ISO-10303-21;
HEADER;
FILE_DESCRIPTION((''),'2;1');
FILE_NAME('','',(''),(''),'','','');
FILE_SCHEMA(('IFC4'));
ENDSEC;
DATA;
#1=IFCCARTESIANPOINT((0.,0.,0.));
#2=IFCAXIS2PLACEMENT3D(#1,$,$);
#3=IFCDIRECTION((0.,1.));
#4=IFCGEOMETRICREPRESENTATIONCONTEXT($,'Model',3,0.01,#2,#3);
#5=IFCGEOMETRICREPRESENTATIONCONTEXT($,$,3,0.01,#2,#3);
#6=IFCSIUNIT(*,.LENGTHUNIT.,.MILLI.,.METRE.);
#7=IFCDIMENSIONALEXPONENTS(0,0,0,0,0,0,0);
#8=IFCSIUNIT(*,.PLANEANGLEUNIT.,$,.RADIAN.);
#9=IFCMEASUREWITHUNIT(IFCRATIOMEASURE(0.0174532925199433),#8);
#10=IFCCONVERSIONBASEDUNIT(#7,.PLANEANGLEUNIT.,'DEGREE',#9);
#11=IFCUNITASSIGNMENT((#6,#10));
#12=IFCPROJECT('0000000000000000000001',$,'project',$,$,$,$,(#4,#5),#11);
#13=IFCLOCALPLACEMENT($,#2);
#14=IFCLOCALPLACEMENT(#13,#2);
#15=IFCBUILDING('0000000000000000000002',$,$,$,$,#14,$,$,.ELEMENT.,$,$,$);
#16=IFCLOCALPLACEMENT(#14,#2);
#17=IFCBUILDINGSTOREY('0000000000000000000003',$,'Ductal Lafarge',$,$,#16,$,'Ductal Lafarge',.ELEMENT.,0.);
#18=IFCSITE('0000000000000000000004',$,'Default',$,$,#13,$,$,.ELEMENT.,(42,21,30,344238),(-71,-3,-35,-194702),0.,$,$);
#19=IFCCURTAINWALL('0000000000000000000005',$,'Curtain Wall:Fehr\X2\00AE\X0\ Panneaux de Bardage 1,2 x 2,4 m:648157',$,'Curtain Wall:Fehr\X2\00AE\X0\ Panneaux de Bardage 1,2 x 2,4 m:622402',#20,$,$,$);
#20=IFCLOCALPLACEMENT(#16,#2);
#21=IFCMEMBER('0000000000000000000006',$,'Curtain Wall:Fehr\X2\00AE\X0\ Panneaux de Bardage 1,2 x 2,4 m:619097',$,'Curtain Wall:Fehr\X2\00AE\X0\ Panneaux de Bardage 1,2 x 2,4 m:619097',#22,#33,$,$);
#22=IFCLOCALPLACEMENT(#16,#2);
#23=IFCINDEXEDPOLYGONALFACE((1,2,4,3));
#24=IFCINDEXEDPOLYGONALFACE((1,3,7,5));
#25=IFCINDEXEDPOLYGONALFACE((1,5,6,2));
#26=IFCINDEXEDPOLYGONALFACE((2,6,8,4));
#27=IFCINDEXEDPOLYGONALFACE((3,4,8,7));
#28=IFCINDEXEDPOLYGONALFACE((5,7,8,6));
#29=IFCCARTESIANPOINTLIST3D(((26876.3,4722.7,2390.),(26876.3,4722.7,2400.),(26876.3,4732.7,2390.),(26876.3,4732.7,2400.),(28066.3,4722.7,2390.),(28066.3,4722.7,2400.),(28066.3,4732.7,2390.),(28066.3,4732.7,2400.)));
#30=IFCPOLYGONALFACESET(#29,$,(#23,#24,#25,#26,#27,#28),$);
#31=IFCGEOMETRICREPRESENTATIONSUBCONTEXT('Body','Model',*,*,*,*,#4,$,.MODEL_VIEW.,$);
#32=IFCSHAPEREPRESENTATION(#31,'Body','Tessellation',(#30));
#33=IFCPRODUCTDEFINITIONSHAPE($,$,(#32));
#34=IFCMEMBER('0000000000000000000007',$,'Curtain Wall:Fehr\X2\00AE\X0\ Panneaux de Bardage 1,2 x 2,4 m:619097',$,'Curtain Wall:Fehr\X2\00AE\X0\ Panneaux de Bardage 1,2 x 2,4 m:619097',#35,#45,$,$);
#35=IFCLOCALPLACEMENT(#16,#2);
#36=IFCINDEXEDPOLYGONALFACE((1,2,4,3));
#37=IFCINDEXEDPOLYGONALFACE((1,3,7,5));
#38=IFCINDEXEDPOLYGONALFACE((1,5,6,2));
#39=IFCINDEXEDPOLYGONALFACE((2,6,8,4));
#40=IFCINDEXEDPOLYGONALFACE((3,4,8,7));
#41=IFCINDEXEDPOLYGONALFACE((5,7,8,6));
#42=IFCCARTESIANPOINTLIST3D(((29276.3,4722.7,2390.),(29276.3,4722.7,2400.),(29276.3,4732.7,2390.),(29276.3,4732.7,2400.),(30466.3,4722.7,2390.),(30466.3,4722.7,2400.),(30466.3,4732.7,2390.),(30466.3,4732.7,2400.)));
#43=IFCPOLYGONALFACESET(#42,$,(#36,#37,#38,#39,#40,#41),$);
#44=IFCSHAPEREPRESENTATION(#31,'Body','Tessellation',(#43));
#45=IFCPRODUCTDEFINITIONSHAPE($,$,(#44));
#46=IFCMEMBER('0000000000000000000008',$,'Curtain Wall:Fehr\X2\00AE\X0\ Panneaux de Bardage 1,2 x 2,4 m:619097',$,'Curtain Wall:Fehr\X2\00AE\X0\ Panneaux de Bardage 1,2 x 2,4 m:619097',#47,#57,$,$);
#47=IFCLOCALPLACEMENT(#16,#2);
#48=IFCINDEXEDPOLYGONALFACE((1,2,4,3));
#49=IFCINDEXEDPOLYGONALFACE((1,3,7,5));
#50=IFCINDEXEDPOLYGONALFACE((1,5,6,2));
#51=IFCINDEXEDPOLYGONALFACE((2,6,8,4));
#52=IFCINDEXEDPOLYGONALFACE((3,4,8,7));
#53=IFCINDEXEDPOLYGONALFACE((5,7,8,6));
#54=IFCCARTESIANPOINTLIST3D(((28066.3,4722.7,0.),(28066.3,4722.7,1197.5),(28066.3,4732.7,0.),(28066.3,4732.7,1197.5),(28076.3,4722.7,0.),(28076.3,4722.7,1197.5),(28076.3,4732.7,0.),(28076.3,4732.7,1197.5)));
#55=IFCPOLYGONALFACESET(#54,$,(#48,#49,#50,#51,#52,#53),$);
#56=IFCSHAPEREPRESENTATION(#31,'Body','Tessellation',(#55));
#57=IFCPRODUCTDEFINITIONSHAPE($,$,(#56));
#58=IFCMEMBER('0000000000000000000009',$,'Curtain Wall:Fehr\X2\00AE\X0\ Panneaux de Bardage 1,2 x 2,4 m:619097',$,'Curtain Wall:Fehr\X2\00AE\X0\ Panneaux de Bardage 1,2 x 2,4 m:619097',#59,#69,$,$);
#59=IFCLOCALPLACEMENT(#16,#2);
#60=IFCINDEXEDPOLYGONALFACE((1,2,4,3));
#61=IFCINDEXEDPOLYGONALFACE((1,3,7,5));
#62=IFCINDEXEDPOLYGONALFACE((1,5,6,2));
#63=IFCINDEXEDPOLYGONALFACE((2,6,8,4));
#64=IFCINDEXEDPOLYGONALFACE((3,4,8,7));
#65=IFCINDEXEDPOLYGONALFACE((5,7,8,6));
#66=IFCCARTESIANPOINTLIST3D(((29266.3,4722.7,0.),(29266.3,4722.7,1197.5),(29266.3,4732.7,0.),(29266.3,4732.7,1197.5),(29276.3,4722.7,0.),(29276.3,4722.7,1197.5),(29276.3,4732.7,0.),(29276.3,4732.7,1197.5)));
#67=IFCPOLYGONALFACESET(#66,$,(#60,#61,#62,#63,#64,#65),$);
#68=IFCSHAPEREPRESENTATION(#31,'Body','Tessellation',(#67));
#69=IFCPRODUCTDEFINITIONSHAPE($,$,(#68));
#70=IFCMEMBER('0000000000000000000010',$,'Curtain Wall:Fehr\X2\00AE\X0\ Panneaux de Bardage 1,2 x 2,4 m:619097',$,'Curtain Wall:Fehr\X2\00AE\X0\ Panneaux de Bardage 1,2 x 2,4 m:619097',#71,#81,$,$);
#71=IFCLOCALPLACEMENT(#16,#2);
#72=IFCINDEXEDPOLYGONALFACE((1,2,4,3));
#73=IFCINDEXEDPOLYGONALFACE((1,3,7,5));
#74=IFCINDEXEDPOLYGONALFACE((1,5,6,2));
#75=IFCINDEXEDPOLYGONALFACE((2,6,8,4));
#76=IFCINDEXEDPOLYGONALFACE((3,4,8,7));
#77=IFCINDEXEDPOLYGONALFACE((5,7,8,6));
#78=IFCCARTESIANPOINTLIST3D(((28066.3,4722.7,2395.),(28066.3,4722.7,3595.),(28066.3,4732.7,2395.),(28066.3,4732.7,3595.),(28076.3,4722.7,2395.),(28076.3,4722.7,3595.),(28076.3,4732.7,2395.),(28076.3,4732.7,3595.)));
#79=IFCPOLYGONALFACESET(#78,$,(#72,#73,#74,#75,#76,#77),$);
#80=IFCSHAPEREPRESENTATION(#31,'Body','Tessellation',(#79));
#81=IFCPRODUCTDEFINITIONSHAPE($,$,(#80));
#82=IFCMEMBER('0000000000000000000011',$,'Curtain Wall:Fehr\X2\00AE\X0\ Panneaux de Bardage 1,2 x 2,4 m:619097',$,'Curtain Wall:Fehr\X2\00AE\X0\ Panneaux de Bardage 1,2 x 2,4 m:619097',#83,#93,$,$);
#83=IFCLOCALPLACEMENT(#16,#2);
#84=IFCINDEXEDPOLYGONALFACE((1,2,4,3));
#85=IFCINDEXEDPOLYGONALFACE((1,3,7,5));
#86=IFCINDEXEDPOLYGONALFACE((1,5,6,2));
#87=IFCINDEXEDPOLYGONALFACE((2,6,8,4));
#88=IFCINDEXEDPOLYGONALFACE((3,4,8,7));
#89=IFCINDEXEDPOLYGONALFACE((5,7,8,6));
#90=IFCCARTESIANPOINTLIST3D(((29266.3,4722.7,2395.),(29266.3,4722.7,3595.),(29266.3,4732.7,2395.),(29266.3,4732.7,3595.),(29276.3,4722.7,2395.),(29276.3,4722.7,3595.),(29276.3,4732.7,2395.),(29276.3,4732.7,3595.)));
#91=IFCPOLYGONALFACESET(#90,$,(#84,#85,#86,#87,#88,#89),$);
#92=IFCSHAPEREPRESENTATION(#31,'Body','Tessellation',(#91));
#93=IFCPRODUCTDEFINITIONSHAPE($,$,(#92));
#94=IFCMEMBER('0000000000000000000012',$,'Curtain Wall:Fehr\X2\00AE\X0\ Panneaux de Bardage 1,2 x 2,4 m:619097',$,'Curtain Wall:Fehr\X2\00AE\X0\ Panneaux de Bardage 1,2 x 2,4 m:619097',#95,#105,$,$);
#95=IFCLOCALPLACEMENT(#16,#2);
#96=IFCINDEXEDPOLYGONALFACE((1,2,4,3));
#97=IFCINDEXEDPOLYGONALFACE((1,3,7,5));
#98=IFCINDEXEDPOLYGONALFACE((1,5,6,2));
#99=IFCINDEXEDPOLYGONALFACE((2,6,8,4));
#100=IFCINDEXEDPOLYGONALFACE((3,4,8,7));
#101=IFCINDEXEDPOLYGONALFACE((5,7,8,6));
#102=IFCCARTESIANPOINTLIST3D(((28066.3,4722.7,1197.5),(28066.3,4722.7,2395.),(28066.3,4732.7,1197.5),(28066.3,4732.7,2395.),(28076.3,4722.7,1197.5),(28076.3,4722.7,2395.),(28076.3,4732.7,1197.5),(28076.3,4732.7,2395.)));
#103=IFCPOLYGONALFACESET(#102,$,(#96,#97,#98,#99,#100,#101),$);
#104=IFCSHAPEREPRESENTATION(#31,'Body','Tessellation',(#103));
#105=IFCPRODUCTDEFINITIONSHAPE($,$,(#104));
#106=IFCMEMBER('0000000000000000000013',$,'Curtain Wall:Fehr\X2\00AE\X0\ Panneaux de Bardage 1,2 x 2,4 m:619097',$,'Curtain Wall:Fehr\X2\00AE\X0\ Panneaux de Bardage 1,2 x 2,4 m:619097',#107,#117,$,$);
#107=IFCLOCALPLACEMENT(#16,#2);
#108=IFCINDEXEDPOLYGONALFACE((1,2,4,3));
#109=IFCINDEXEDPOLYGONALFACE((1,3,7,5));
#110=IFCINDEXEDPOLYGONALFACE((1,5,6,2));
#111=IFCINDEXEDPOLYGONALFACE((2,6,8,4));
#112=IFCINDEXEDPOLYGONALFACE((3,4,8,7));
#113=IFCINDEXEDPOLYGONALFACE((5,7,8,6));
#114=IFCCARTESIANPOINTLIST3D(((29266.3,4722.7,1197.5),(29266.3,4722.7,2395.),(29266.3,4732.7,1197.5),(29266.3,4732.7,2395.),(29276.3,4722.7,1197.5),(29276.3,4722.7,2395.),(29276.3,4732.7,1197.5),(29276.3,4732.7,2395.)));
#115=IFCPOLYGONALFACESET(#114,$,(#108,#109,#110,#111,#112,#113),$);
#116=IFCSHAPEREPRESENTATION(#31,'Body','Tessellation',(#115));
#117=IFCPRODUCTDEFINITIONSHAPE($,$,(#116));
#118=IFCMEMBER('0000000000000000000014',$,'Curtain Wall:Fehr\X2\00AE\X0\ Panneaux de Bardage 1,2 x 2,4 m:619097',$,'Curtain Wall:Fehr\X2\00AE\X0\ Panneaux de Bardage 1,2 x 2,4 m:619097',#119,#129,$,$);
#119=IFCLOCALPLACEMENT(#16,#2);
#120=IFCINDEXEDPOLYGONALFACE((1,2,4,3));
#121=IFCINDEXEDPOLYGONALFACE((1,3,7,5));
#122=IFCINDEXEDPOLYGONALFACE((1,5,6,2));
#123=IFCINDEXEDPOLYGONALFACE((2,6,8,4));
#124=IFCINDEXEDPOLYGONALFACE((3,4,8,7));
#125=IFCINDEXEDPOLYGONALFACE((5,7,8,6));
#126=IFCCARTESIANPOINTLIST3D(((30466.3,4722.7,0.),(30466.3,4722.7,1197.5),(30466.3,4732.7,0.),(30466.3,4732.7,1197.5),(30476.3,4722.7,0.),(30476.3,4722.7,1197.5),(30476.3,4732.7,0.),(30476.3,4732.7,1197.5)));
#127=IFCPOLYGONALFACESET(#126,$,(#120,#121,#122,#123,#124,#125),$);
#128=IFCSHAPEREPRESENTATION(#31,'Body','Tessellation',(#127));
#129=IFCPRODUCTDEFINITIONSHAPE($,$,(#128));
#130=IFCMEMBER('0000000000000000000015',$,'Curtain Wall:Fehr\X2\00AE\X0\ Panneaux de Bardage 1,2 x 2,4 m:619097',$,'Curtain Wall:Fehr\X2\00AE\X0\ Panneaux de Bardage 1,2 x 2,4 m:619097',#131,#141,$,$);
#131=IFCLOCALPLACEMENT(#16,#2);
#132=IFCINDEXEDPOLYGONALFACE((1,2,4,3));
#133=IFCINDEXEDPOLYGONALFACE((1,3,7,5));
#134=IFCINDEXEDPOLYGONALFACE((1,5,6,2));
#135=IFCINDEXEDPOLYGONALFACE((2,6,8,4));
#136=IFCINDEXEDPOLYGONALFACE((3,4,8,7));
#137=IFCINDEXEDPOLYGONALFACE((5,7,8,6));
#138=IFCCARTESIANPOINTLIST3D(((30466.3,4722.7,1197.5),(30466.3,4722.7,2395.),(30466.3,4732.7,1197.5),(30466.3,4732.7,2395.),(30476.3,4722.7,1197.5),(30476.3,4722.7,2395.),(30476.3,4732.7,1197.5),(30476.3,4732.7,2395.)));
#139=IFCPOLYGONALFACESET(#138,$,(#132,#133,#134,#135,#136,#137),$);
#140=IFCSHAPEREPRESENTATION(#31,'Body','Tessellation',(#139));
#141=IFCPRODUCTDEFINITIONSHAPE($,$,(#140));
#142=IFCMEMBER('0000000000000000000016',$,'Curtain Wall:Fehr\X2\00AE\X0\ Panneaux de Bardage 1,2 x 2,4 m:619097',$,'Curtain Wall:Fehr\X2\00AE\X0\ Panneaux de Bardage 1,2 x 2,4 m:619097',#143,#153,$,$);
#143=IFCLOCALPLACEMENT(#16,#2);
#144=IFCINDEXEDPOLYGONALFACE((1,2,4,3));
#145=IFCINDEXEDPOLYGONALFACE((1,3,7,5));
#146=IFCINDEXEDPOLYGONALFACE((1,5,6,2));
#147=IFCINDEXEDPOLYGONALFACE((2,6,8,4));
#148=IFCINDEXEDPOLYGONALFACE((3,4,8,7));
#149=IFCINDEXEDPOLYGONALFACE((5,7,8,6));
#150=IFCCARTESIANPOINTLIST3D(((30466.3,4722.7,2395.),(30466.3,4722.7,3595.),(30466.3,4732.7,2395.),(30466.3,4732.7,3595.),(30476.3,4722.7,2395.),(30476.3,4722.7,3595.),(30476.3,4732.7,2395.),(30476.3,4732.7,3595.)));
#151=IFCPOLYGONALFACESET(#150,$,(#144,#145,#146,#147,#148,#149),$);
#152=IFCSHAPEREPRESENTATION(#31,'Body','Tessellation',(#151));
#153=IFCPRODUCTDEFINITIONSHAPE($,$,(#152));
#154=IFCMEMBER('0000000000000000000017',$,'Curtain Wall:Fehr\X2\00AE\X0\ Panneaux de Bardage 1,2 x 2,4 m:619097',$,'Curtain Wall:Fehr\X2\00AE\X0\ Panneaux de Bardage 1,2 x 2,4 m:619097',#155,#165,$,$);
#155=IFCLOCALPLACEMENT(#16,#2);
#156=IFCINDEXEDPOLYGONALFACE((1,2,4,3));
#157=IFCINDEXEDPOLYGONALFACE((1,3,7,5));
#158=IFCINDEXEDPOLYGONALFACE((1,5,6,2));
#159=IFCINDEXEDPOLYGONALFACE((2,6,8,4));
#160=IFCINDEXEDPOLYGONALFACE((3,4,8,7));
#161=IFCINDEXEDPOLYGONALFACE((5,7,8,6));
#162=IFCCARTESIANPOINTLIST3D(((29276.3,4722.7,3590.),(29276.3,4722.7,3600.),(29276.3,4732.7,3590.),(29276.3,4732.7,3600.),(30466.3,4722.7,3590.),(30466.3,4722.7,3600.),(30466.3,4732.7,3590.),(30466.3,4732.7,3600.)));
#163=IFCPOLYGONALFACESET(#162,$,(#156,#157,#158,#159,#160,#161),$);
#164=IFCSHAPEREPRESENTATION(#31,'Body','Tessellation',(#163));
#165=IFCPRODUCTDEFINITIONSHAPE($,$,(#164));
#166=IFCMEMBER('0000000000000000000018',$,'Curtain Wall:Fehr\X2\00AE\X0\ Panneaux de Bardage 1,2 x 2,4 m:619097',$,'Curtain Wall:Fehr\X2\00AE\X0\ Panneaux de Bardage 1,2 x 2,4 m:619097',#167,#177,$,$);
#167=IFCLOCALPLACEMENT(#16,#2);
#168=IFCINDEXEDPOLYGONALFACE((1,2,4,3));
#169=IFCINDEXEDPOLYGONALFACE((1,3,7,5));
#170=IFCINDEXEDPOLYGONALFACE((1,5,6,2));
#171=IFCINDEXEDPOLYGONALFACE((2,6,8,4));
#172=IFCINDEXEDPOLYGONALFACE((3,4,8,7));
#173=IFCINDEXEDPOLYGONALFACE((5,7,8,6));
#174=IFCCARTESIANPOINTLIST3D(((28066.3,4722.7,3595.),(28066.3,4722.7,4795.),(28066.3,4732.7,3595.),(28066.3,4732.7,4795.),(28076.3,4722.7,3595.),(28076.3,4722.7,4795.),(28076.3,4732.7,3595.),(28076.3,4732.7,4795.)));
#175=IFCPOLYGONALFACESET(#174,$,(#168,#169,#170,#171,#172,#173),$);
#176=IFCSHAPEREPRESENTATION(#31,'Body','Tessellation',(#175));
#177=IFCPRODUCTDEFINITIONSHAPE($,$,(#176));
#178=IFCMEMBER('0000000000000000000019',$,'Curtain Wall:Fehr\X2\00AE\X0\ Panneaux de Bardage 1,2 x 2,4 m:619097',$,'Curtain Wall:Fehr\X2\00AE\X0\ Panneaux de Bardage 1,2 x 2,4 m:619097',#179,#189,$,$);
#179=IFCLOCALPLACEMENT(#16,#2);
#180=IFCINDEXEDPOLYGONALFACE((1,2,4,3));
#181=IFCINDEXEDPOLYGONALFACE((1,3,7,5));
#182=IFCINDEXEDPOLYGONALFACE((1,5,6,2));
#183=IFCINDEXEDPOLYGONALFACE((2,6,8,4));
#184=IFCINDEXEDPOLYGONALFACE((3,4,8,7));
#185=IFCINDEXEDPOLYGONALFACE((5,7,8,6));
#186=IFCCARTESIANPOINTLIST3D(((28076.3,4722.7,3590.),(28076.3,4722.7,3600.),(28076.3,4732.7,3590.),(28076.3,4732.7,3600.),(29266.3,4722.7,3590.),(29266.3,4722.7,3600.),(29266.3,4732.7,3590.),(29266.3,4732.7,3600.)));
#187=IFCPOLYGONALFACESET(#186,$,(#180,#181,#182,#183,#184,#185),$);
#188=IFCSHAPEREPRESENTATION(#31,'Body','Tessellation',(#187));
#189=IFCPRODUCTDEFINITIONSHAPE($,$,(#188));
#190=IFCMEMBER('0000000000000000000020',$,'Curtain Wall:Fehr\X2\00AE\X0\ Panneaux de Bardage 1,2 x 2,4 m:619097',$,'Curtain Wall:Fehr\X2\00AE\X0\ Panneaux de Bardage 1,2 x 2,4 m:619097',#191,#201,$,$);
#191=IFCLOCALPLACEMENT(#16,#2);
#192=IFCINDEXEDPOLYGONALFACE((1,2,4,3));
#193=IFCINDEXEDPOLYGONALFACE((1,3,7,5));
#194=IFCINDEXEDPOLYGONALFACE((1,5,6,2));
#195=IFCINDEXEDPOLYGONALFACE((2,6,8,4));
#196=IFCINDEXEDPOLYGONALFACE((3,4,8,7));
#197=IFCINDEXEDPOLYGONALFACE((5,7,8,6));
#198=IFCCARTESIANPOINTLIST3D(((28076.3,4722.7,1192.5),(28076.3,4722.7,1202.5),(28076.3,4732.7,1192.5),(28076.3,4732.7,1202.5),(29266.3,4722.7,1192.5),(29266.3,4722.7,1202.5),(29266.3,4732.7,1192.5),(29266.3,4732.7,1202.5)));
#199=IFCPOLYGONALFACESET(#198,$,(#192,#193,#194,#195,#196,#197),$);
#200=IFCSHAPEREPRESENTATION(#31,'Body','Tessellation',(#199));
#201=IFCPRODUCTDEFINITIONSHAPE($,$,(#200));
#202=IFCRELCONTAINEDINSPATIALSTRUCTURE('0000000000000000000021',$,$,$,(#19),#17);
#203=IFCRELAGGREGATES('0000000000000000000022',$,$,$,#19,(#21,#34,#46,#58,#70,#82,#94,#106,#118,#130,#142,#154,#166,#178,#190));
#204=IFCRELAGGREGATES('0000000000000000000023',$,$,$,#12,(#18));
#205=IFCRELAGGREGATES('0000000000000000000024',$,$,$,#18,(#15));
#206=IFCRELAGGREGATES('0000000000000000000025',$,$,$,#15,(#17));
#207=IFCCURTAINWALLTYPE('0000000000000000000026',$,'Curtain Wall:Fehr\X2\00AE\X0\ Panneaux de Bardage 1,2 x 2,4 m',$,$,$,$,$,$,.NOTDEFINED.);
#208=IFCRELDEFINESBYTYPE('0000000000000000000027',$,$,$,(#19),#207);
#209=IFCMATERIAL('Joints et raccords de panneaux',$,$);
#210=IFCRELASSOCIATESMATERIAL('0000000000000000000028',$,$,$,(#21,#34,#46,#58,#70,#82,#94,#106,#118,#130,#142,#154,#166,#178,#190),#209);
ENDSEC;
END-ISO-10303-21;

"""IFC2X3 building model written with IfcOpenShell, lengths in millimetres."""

from ifc_helpers import new_model, entity, si_unit, converted_unit, direction, frame, frame_2d, origin, place, context, subcontext, project, spatial, rectangle, extrude, material, type_object, element, aggregate, save


model = new_model("IFC2X3")

# Units and contexts
model_context = context("Model", 3, precision=0.01, world=origin(), true_north=direction((0.0, 1.0)))
context_of_model = context(None, 3, precision=0.01, world=origin(), true_north=direction((0.0, 1.0)))
body_context = subcontext(model_context, "Body", "Model", "MODEL_VIEW")
ifc_project = project(units=[si_unit("LENGTHUNIT", "METRE", prefix="MILLI"), converted_unit("PLANEANGLEUNIT", "DEGREE", entity("IfcRatioMeasure", 0.0174532925199433), si_unit("PLANEANGLEUNIT", "RADIAN"), dimensions=[0, 0, 0, 0, 0, 0, 0])], contexts=[model_context, context_of_model])

# Site, building, storey
site_placement = place(None, origin())
site = spatial("IfcSite", under=ifc_project, at=site_placement, Name="Default", CompositionType="ELEMENT", RefLatitude=(42, 21, 30, 344238), RefLongitude=(-71, -3, -35, -194702), RefElevation=0.0)
building_placement = place(site_placement, origin())
building = spatial("IfcBuilding", under=site, at=building_placement, CompositionType="ELEMENT")
storey_placement = place(building_placement, origin())
storey = spatial("IfcBuildingStorey", under=building, at=storey_placement, Name="Ductal Lafarge", LongName="Ductal Lafarge", CompositionType="ELEMENT", Elevation=0.0)

# Curtain wall, members
curtain_wall_type_1 = type_object("IfcCurtainWallType", Name="Curtain Wall:Fehr® Panneaux de Bardage 1,2 x 2,4 m", PredefinedType="NOTDEFINED")
curtain_wall_1_placement = place(storey_placement, origin())
curtain_wall_1 = element("IfcCurtainWall", 1, at=curtain_wall_1_placement, inside=storey, type_object=curtain_wall_type_1, Name="Curtain Wall:Fehr® Panneaux de Bardage 1,2 x 2,4 m:648157", ObjectType="Curtain Wall:Fehr® Panneaux de Bardage 1,2 x 2,4 m:622402")
ifc_material_1 = material(Name="Joints et raccords de panneaux")
member_1_placement = place(curtain_wall_1_placement, frame((26876.3, 4722.7, 2390.0)))
member_1 = element("IfcMember", 2, at=member_1_placement, material=ifc_material_1, Name="Curtain Wall:Fehr® Panneaux de Bardage 1,2 x 2,4 m:619097", ObjectType="Curtain Wall:Fehr® Panneaux de Bardage 1,2 x 2,4 m:619097", context=body_context, shape_type="SweptSolid", body=[
    extrude(rectangle(XDim=1190.0, YDim=10.0, at=frame_2d((0.0, 0.0), x_axis=(1.0, 0.0))), frame((595.0, 5.0, 0.0), z_axis=(0.0, 0.0, 1.0), x_axis=(-1.0, 0.0, 0.0)), (0.0, 0.0, 1.0), 10.0),
])
member_2_placement = place(curtain_wall_1_placement, frame((29276.3, 4722.7, 2390.0)))
member_2 = element("IfcMember", 3, at=member_2_placement, material=ifc_material_1, Name="Curtain Wall:Fehr® Panneaux de Bardage 1,2 x 2,4 m:619097", ObjectType="Curtain Wall:Fehr® Panneaux de Bardage 1,2 x 2,4 m:619097", context=body_context, shape_type="SweptSolid", body=[
    extrude(rectangle(XDim=1190.0, YDim=10.0, at=frame_2d((0.0, 0.0), x_axis=(1.0, 0.0))), frame((595.0, 5.0, 0.0), z_axis=(0.0, 0.0, 1.0), x_axis=(-1.0, 0.0, 0.0)), (0.0, 0.0, 1.0), 10.0),
])
member_3_placement = place(curtain_wall_1_placement, frame((28066.3, 4722.7, 0.0)))
member_3 = element("IfcMember", 4, at=member_3_placement, material=ifc_material_1, Name="Curtain Wall:Fehr® Panneaux de Bardage 1,2 x 2,4 m:619097", ObjectType="Curtain Wall:Fehr® Panneaux de Bardage 1,2 x 2,4 m:619097", context=body_context, shape_type="SweptSolid", body=[
    extrude(rectangle(XDim=10.0, YDim=10.0, at=frame_2d((0.0, 0.0), x_axis=(1.0, 0.0))), frame((5.0, 5.0, 0.0), z_axis=(0.0, 0.0, 1.0), x_axis=(0.0, 1.0, 0.0)), (0.0, 0.0, 1.0), 1197.5),
])
member_4_placement = place(curtain_wall_1_placement, frame((29266.3, 4722.7, 0.0)))
member_4 = element("IfcMember", 5, at=member_4_placement, material=ifc_material_1, Name="Curtain Wall:Fehr® Panneaux de Bardage 1,2 x 2,4 m:619097", ObjectType="Curtain Wall:Fehr® Panneaux de Bardage 1,2 x 2,4 m:619097", context=body_context, shape_type="SweptSolid", body=[
    extrude(rectangle(XDim=10.0, YDim=10.0, at=frame_2d((0.0, 0.0), x_axis=(1.0, 0.0))), frame((5.0, 5.0, 0.0), z_axis=(0.0, 0.0, 1.0), x_axis=(0.0, 1.0, 0.0)), (0.0, 0.0, 1.0), 1197.5),
])
member_5_placement = place(curtain_wall_1_placement, frame((28066.3, 4722.7, 2395.0)))
member_5 = element("IfcMember", 6, at=member_5_placement, material=ifc_material_1, Name="Curtain Wall:Fehr® Panneaux de Bardage 1,2 x 2,4 m:619097", ObjectType="Curtain Wall:Fehr® Panneaux de Bardage 1,2 x 2,4 m:619097", context=body_context, shape_type="SweptSolid", body=[
    extrude(rectangle(XDim=10.0, YDim=10.0, at=frame_2d((0.0, 0.0), x_axis=(1.0, 0.0))), frame((5.0, 5.0, 0.0), z_axis=(0.0, 0.0, 1.0), x_axis=(0.0, 1.0, 0.0)), (0.0, 0.0, 1.0), 1200.0),
])
member_6_placement = place(curtain_wall_1_placement, frame((29266.3, 4722.7, 2395.0)))
member_6 = element("IfcMember", 7, at=member_6_placement, material=ifc_material_1, Name="Curtain Wall:Fehr® Panneaux de Bardage 1,2 x 2,4 m:619097", ObjectType="Curtain Wall:Fehr® Panneaux de Bardage 1,2 x 2,4 m:619097", context=body_context, shape_type="SweptSolid", body=[
    extrude(rectangle(XDim=10.0, YDim=10.0, at=frame_2d((0.0, 0.0), x_axis=(1.0, 0.0))), frame((5.0, 5.0, 0.0), z_axis=(0.0, 0.0, 1.0), x_axis=(0.0, 1.0, 0.0)), (0.0, 0.0, 1.0), 1200.0),
])
member_7_placement = place(curtain_wall_1_placement, frame((28066.3, 4722.7, 1197.5)))
member_7 = element("IfcMember", 8, at=member_7_placement, material=ifc_material_1, Name="Curtain Wall:Fehr® Panneaux de Bardage 1,2 x 2,4 m:619097", ObjectType="Curtain Wall:Fehr® Panneaux de Bardage 1,2 x 2,4 m:619097", context=body_context, shape_type="SweptSolid", body=[
    extrude(rectangle(XDim=10.0, YDim=10.0, at=frame_2d((0.0, 0.0), x_axis=(1.0, 0.0))), frame((5.0, 5.0, 0.0), z_axis=(0.0, 0.0, 1.0), x_axis=(0.0, 1.0, 0.0)), (0.0, 0.0, 1.0), 1197.5),
])
member_8_placement = place(curtain_wall_1_placement, frame((29266.3, 4722.7, 1197.5)))
member_8 = element("IfcMember", 9, at=member_8_placement, material=ifc_material_1, Name="Curtain Wall:Fehr® Panneaux de Bardage 1,2 x 2,4 m:619097", ObjectType="Curtain Wall:Fehr® Panneaux de Bardage 1,2 x 2,4 m:619097", context=body_context, shape_type="SweptSolid", body=[
    extrude(rectangle(XDim=10.0, YDim=10.0, at=frame_2d((0.0, 0.0), x_axis=(1.0, 0.0))), frame((5.0, 5.0, 0.0), z_axis=(0.0, 0.0, 1.0), x_axis=(0.0, 1.0, 0.0)), (0.0, 0.0, 1.0), 1197.5),
])
member_9_placement = place(curtain_wall_1_placement, frame((30466.3, 4722.7, 0.0)))
member_9 = element("IfcMember", 10, at=member_9_placement, material=ifc_material_1, Name="Curtain Wall:Fehr® Panneaux de Bardage 1,2 x 2,4 m:619097", ObjectType="Curtain Wall:Fehr® Panneaux de Bardage 1,2 x 2,4 m:619097", context=body_context, shape_type="SweptSolid", body=[
    extrude(rectangle(XDim=10.0, YDim=10.0, at=frame_2d((0.0, 0.0), x_axis=(1.0, 0.0))), frame((5.0, 5.0, 0.0), z_axis=(0.0, 0.0, 1.0), x_axis=(0.0, 1.0, 0.0)), (0.0, 0.0, 1.0), 1197.5),
])
member_10_placement = place(curtain_wall_1_placement, frame((30466.3, 4722.7, 1197.5)))
member_10 = element("IfcMember", 11, at=member_10_placement, material=ifc_material_1, Name="Curtain Wall:Fehr® Panneaux de Bardage 1,2 x 2,4 m:619097", ObjectType="Curtain Wall:Fehr® Panneaux de Bardage 1,2 x 2,4 m:619097", context=body_context, shape_type="SweptSolid", body=[
    extrude(rectangle(XDim=10.0, YDim=10.0, at=frame_2d((0.0, 0.0), x_axis=(1.0, 0.0))), frame((5.0, 5.0, 0.0), z_axis=(0.0, 0.0, 1.0), x_axis=(0.0, 1.0, 0.0)), (0.0, 0.0, 1.0), 1197.5),
])
member_11_placement = place(curtain_wall_1_placement, frame((30466.3, 4722.7, 2395.0)))
member_11 = element("IfcMember", 12, at=member_11_placement, material=ifc_material_1, Name="Curtain Wall:Fehr® Panneaux de Bardage 1,2 x 2,4 m:619097", ObjectType="Curtain Wall:Fehr® Panneaux de Bardage 1,2 x 2,4 m:619097", context=body_context, shape_type="SweptSolid", body=[
    extrude(rectangle(XDim=10.0, YDim=10.0, at=frame_2d((0.0, 0.0), x_axis=(1.0, 0.0))), frame((5.0, 5.0, 0.0), z_axis=(0.0, 0.0, 1.0), x_axis=(0.0, 1.0, 0.0)), (0.0, 0.0, 1.0), 1200.0),
])
member_12_placement = place(curtain_wall_1_placement, frame((29276.3, 4722.7, 3590.0)))
member_12 = element("IfcMember", 13, at=member_12_placement, material=ifc_material_1, Name="Curtain Wall:Fehr® Panneaux de Bardage 1,2 x 2,4 m:619097", ObjectType="Curtain Wall:Fehr® Panneaux de Bardage 1,2 x 2,4 m:619097", context=body_context, shape_type="SweptSolid", body=[
    extrude(rectangle(XDim=1190.0, YDim=10.0, at=frame_2d((0.0, 0.0), x_axis=(1.0, 0.0))), frame((595.0, 5.0, 0.0), z_axis=(0.0, 0.0, 1.0), x_axis=(-1.0, 0.0, 0.0)), (0.0, 0.0, 1.0), 10.0),
])
member_13_placement = place(curtain_wall_1_placement, frame((28066.3, 4722.7, 3595.0)))
member_13 = element("IfcMember", 14, at=member_13_placement, material=ifc_material_1, Name="Curtain Wall:Fehr® Panneaux de Bardage 1,2 x 2,4 m:619097", ObjectType="Curtain Wall:Fehr® Panneaux de Bardage 1,2 x 2,4 m:619097", context=body_context, shape_type="SweptSolid", body=[
    extrude(rectangle(XDim=10.0, YDim=10.0, at=frame_2d((0.0, 0.0), x_axis=(1.0, 0.0))), frame((5.0, 5.0, 0.0), z_axis=(0.0, 0.0, 1.0), x_axis=(0.0, 1.0, 0.0)), (0.0, 0.0, 1.0), 1200.0),
])
member_14_placement = place(curtain_wall_1_placement, frame((28076.3, 4722.7, 3590.0)))
member_14 = element("IfcMember", 15, at=member_14_placement, material=ifc_material_1, Name="Curtain Wall:Fehr® Panneaux de Bardage 1,2 x 2,4 m:619097", ObjectType="Curtain Wall:Fehr® Panneaux de Bardage 1,2 x 2,4 m:619097", context=body_context, shape_type="SweptSolid", body=[
    extrude(rectangle(XDim=1190.0, YDim=10.0, at=frame_2d((0.0, 0.0), x_axis=(1.0, 0.0))), frame((595.0, 5.0, 0.0), z_axis=(0.0, 0.0, 1.0), x_axis=(-1.0, 0.0, 0.0)), (0.0, 0.0, 1.0), 10.0),
])
member_15_placement = place(curtain_wall_1_placement, frame((28076.3, 4722.7, 1192.5)))
member_15 = element("IfcMember", 16, at=member_15_placement, material=ifc_material_1, Name="Curtain Wall:Fehr® Panneaux de Bardage 1,2 x 2,4 m:619097", ObjectType="Curtain Wall:Fehr® Panneaux de Bardage 1,2 x 2,4 m:619097", context=body_context, shape_type="SweptSolid", body=[
    extrude(rectangle(XDim=1190.0, YDim=10.0, at=frame_2d((0.0, 0.0), x_axis=(1.0, 0.0))), frame((595.0, 5.0, 0.0), z_axis=(0.0, 0.0, 1.0), x_axis=(-1.0, 0.0, 0.0)), (0.0, 0.0, 1.0), 10.0),
])

aggregate(curtain_wall_1, [member_1, member_2, member_3, member_4, member_5, member_6, member_7, member_8, member_9, member_10, member_11, member_12, member_13, member_14, member_15])

save(model, "model.ifc")
